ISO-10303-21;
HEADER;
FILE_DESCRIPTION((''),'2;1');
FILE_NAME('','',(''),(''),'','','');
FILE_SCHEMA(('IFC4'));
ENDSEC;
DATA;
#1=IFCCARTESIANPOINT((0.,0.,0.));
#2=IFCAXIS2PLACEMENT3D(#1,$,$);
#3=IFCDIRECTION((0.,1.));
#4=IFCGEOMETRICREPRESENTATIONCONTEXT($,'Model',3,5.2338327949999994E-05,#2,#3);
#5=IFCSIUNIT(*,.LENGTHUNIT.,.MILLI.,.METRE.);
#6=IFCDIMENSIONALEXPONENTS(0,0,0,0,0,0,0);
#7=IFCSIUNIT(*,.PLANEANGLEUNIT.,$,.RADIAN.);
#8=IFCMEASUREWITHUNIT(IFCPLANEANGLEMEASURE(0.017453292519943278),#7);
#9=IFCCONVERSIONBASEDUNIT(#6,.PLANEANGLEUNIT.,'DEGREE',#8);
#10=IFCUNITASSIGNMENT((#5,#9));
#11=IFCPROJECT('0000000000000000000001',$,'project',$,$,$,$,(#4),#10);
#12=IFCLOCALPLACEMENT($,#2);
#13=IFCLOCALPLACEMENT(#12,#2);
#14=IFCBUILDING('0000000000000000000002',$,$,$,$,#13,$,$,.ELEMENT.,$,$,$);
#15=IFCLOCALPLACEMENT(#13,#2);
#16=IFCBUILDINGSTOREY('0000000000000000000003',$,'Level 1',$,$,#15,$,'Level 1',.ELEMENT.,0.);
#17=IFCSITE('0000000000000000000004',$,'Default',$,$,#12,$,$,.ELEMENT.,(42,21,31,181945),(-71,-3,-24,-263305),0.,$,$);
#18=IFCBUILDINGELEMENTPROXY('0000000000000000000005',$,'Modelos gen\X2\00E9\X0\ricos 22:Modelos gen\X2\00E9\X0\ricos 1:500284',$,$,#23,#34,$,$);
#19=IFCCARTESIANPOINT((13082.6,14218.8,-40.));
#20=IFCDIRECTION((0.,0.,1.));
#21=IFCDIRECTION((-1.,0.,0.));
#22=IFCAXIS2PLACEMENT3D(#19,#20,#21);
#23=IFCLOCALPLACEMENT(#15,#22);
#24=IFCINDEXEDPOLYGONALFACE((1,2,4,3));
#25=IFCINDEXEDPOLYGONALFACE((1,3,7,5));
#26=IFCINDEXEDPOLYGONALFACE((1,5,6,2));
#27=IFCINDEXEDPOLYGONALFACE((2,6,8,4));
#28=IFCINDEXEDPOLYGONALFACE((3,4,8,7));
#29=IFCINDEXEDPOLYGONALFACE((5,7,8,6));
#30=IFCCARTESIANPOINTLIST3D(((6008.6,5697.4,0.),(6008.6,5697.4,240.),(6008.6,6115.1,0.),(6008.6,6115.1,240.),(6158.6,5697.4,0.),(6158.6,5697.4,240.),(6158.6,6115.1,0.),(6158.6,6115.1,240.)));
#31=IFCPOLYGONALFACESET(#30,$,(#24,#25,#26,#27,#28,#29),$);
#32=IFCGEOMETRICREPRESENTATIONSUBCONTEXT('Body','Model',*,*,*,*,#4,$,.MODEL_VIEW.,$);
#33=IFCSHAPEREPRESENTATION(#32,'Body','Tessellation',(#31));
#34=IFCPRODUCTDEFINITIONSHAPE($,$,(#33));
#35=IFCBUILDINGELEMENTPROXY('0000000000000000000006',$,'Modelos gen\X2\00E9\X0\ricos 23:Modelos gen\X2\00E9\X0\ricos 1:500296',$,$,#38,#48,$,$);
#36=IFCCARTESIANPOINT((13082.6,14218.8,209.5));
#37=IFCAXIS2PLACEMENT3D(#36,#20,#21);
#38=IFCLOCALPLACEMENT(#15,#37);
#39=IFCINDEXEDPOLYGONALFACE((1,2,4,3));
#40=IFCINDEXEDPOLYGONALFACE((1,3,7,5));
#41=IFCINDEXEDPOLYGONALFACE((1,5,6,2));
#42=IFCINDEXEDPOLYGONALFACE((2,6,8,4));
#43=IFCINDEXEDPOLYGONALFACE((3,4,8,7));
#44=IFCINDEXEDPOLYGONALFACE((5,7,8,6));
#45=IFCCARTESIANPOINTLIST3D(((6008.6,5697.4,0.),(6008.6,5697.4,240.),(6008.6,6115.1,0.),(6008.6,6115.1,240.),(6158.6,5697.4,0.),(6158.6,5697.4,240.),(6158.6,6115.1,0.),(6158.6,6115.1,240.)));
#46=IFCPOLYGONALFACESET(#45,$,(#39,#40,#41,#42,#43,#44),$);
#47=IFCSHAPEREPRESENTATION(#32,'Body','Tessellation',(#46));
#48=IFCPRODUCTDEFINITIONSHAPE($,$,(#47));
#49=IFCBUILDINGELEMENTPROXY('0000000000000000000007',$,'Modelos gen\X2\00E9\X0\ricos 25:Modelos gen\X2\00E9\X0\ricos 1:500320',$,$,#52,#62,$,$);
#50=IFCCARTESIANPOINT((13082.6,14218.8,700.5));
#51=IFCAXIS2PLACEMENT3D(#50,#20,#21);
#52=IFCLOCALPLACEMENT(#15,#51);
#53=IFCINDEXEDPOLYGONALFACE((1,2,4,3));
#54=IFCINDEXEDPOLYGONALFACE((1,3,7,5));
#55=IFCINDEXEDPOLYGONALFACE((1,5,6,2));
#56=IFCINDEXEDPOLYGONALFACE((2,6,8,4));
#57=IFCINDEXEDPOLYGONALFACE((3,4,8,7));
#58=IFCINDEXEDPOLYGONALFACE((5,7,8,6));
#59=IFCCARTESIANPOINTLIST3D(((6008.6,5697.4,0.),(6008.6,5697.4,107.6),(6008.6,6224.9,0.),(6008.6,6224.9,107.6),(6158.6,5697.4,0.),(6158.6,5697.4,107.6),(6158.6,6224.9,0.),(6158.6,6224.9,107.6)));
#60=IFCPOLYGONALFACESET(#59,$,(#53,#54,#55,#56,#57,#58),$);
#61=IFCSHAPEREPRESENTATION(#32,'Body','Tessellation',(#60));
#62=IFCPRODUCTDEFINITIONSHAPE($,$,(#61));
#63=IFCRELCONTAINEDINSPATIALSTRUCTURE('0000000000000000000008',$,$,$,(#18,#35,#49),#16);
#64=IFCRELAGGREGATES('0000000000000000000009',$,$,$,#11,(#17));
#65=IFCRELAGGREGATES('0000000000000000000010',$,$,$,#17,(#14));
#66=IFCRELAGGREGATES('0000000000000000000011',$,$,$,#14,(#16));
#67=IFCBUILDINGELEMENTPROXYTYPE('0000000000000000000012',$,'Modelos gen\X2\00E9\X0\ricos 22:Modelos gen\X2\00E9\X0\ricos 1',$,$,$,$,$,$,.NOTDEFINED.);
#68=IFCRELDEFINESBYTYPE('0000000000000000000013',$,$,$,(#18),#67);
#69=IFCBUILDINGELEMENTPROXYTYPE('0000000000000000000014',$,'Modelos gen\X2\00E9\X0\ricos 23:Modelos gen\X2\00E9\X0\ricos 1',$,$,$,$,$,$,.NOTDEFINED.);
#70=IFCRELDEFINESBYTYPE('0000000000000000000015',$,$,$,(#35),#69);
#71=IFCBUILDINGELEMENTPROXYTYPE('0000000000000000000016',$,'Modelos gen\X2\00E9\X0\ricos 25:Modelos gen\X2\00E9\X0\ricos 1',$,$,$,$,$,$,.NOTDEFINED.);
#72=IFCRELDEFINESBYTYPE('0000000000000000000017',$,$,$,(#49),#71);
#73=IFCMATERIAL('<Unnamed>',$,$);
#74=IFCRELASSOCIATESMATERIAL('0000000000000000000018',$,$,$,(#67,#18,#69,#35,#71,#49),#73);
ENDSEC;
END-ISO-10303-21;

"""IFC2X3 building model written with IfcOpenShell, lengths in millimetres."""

from ifc_helpers import new_model, entity, si_unit, converted_unit, direction, frame, frame_2d, origin, place, context, subcontext, project, spatial, rectangle, extrude, source, transform, mapped, material, type_object, type_shapes, element, save


model = new_model("IFC2X3")

# Units and contexts
model_context = context("Model", 3, precision=5.2338327949999994e-05, world=origin(), true_north=direction((0.0, 1.0)))
body_context = subcontext(model_context, "Body", "Model", "MODEL_VIEW")
ifc_project = project(units=[si_unit("LENGTHUNIT", "METRE", prefix="MILLI"), converted_unit("PLANEANGLEUNIT", "DEGREE", entity("IfcPlaneAngleMeasure", 0.017453292519943278), si_unit("PLANEANGLEUNIT", "RADIAN"), dimensions=[0, 0, 0, 0, 0, 0, 0])], contexts=[model_context])

# Site, building, storey
site_placement = place(None, origin())
site = spatial("IfcSite", under=ifc_project, at=site_placement, Name="Default", CompositionType="ELEMENT", RefLatitude=(42, 21, 31, 181945), RefLongitude=(-71, -3, -24, -263305), RefElevation=0.0)
building_placement = place(site_placement, origin())
building = spatial("IfcBuilding", under=site, at=building_placement, CompositionType="ELEMENT")
storey_placement = place(building_placement, origin())
storey = spatial("IfcBuildingStorey", under=building, at=storey_placement, Name="Level 1", LongName="Level 1", CompositionType="ELEMENT", Elevation=0.0)

# Building element proxies
ifc_material_1 = material(Name="<Unnamed>")
building_element_proxy_type_1 = type_object("IfcBuildingElementProxyType", Name="Modelos genéricos 22:Modelos genéricos 1", PredefinedType="NOTDEFINED", material=ifc_material_1)
shared_shape_1 = source(origin(), body_context, "Body", "SweptSolid", [
    extrude(rectangle(XDim=150.0, YDim=417.7, at=frame_2d((0.0, 0.0), x_axis=(1.0, 0.0))), frame((6083.6, 5906.2, 0.0), z_axis=(0.0, 0.0, 1.0), x_axis=(-1.0, 0.0, 0.0)), (0.0, 0.0, 1.0), 240.0),
])
type_shapes(building_element_proxy_type_1, [shared_shape_1])
proxy_1_placement = place(storey_placement, frame((13082.6, 14218.8, -40.0), z_axis=(0.0, 0.0, 1.0), x_axis=(-1.0, 0.0, 0.0)))
element("IfcBuildingElementProxy", 1, at=proxy_1_placement, inside=storey, type_object=building_element_proxy_type_1, material=ifc_material_1, Name="Modelos genéricos 22:Modelos genéricos 1:500284", context=body_context, shape_type="MappedRepresentation", body=[
    mapped(shared_shape_1, transform((0.0, 0.0, 0.0), scale=1.0)),
])
building_element_proxy_type_2 = type_object("IfcBuildingElementProxyType", Name="Modelos genéricos 23:Modelos genéricos 1", PredefinedType="NOTDEFINED", material=ifc_material_1)
shared_shape_2 = source(origin(), body_context, "Body", "SweptSolid", [
    extrude(rectangle(XDim=150.0, YDim=417.7, at=frame_2d((0.0, 0.0), x_axis=(1.0, 0.0))), frame((6083.6, 5906.2, 0.0), z_axis=(0.0, 0.0, 1.0), x_axis=(-1.0, 0.0, 0.0)), (0.0, 0.0, 1.0), 240.0),
])
type_shapes(building_element_proxy_type_2, [shared_shape_2])
proxy_2_placement = place(storey_placement, frame((13082.6, 14218.8, 209.5), z_axis=(0.0, 0.0, 1.0), x_axis=(-1.0, 0.0, 0.0)))
element("IfcBuildingElementProxy", 2, at=proxy_2_placement, inside=storey, type_object=building_element_proxy_type_2, material=ifc_material_1, Name="Modelos genéricos 23:Modelos genéricos 1:500296", context=body_context, shape_type="MappedRepresentation", body=[
    mapped(shared_shape_2, transform((0.0, 0.0, 0.0), scale=1.0)),
])
building_element_proxy_type_3 = type_object("IfcBuildingElementProxyType", Name="Modelos genéricos 25:Modelos genéricos 1", PredefinedType="NOTDEFINED", material=ifc_material_1)
shared_shape_3 = source(origin(), body_context, "Body", "SweptSolid", [
    extrude(rectangle(XDim=150.0, YDim=527.5, at=frame_2d((0.0, 0.0), x_axis=(1.0, 0.0))), frame((6083.6, 5961.1, 0.0), z_axis=(0.0, 0.0, 1.0), x_axis=(-1.0, 0.0, 0.0)), (0.0, 0.0, 1.0), 107.6),
])
type_shapes(building_element_proxy_type_3, [shared_shape_3])
proxy_3_placement = place(storey_placement, frame((13082.6, 14218.8, 700.5), z_axis=(0.0, 0.0, 1.0), x_axis=(-1.0, 0.0, 0.0)))
element("IfcBuildingElementProxy", 3, at=proxy_3_placement, inside=storey, type_object=building_element_proxy_type_3, material=ifc_material_1, Name="Modelos genéricos 25:Modelos genéricos 1:500320", context=body_context, shape_type="MappedRepresentation", body=[
    mapped(shared_shape_3, transform((0.0, 0.0, 0.0), scale=1.0)),
])

save(model, "model.ifc")
